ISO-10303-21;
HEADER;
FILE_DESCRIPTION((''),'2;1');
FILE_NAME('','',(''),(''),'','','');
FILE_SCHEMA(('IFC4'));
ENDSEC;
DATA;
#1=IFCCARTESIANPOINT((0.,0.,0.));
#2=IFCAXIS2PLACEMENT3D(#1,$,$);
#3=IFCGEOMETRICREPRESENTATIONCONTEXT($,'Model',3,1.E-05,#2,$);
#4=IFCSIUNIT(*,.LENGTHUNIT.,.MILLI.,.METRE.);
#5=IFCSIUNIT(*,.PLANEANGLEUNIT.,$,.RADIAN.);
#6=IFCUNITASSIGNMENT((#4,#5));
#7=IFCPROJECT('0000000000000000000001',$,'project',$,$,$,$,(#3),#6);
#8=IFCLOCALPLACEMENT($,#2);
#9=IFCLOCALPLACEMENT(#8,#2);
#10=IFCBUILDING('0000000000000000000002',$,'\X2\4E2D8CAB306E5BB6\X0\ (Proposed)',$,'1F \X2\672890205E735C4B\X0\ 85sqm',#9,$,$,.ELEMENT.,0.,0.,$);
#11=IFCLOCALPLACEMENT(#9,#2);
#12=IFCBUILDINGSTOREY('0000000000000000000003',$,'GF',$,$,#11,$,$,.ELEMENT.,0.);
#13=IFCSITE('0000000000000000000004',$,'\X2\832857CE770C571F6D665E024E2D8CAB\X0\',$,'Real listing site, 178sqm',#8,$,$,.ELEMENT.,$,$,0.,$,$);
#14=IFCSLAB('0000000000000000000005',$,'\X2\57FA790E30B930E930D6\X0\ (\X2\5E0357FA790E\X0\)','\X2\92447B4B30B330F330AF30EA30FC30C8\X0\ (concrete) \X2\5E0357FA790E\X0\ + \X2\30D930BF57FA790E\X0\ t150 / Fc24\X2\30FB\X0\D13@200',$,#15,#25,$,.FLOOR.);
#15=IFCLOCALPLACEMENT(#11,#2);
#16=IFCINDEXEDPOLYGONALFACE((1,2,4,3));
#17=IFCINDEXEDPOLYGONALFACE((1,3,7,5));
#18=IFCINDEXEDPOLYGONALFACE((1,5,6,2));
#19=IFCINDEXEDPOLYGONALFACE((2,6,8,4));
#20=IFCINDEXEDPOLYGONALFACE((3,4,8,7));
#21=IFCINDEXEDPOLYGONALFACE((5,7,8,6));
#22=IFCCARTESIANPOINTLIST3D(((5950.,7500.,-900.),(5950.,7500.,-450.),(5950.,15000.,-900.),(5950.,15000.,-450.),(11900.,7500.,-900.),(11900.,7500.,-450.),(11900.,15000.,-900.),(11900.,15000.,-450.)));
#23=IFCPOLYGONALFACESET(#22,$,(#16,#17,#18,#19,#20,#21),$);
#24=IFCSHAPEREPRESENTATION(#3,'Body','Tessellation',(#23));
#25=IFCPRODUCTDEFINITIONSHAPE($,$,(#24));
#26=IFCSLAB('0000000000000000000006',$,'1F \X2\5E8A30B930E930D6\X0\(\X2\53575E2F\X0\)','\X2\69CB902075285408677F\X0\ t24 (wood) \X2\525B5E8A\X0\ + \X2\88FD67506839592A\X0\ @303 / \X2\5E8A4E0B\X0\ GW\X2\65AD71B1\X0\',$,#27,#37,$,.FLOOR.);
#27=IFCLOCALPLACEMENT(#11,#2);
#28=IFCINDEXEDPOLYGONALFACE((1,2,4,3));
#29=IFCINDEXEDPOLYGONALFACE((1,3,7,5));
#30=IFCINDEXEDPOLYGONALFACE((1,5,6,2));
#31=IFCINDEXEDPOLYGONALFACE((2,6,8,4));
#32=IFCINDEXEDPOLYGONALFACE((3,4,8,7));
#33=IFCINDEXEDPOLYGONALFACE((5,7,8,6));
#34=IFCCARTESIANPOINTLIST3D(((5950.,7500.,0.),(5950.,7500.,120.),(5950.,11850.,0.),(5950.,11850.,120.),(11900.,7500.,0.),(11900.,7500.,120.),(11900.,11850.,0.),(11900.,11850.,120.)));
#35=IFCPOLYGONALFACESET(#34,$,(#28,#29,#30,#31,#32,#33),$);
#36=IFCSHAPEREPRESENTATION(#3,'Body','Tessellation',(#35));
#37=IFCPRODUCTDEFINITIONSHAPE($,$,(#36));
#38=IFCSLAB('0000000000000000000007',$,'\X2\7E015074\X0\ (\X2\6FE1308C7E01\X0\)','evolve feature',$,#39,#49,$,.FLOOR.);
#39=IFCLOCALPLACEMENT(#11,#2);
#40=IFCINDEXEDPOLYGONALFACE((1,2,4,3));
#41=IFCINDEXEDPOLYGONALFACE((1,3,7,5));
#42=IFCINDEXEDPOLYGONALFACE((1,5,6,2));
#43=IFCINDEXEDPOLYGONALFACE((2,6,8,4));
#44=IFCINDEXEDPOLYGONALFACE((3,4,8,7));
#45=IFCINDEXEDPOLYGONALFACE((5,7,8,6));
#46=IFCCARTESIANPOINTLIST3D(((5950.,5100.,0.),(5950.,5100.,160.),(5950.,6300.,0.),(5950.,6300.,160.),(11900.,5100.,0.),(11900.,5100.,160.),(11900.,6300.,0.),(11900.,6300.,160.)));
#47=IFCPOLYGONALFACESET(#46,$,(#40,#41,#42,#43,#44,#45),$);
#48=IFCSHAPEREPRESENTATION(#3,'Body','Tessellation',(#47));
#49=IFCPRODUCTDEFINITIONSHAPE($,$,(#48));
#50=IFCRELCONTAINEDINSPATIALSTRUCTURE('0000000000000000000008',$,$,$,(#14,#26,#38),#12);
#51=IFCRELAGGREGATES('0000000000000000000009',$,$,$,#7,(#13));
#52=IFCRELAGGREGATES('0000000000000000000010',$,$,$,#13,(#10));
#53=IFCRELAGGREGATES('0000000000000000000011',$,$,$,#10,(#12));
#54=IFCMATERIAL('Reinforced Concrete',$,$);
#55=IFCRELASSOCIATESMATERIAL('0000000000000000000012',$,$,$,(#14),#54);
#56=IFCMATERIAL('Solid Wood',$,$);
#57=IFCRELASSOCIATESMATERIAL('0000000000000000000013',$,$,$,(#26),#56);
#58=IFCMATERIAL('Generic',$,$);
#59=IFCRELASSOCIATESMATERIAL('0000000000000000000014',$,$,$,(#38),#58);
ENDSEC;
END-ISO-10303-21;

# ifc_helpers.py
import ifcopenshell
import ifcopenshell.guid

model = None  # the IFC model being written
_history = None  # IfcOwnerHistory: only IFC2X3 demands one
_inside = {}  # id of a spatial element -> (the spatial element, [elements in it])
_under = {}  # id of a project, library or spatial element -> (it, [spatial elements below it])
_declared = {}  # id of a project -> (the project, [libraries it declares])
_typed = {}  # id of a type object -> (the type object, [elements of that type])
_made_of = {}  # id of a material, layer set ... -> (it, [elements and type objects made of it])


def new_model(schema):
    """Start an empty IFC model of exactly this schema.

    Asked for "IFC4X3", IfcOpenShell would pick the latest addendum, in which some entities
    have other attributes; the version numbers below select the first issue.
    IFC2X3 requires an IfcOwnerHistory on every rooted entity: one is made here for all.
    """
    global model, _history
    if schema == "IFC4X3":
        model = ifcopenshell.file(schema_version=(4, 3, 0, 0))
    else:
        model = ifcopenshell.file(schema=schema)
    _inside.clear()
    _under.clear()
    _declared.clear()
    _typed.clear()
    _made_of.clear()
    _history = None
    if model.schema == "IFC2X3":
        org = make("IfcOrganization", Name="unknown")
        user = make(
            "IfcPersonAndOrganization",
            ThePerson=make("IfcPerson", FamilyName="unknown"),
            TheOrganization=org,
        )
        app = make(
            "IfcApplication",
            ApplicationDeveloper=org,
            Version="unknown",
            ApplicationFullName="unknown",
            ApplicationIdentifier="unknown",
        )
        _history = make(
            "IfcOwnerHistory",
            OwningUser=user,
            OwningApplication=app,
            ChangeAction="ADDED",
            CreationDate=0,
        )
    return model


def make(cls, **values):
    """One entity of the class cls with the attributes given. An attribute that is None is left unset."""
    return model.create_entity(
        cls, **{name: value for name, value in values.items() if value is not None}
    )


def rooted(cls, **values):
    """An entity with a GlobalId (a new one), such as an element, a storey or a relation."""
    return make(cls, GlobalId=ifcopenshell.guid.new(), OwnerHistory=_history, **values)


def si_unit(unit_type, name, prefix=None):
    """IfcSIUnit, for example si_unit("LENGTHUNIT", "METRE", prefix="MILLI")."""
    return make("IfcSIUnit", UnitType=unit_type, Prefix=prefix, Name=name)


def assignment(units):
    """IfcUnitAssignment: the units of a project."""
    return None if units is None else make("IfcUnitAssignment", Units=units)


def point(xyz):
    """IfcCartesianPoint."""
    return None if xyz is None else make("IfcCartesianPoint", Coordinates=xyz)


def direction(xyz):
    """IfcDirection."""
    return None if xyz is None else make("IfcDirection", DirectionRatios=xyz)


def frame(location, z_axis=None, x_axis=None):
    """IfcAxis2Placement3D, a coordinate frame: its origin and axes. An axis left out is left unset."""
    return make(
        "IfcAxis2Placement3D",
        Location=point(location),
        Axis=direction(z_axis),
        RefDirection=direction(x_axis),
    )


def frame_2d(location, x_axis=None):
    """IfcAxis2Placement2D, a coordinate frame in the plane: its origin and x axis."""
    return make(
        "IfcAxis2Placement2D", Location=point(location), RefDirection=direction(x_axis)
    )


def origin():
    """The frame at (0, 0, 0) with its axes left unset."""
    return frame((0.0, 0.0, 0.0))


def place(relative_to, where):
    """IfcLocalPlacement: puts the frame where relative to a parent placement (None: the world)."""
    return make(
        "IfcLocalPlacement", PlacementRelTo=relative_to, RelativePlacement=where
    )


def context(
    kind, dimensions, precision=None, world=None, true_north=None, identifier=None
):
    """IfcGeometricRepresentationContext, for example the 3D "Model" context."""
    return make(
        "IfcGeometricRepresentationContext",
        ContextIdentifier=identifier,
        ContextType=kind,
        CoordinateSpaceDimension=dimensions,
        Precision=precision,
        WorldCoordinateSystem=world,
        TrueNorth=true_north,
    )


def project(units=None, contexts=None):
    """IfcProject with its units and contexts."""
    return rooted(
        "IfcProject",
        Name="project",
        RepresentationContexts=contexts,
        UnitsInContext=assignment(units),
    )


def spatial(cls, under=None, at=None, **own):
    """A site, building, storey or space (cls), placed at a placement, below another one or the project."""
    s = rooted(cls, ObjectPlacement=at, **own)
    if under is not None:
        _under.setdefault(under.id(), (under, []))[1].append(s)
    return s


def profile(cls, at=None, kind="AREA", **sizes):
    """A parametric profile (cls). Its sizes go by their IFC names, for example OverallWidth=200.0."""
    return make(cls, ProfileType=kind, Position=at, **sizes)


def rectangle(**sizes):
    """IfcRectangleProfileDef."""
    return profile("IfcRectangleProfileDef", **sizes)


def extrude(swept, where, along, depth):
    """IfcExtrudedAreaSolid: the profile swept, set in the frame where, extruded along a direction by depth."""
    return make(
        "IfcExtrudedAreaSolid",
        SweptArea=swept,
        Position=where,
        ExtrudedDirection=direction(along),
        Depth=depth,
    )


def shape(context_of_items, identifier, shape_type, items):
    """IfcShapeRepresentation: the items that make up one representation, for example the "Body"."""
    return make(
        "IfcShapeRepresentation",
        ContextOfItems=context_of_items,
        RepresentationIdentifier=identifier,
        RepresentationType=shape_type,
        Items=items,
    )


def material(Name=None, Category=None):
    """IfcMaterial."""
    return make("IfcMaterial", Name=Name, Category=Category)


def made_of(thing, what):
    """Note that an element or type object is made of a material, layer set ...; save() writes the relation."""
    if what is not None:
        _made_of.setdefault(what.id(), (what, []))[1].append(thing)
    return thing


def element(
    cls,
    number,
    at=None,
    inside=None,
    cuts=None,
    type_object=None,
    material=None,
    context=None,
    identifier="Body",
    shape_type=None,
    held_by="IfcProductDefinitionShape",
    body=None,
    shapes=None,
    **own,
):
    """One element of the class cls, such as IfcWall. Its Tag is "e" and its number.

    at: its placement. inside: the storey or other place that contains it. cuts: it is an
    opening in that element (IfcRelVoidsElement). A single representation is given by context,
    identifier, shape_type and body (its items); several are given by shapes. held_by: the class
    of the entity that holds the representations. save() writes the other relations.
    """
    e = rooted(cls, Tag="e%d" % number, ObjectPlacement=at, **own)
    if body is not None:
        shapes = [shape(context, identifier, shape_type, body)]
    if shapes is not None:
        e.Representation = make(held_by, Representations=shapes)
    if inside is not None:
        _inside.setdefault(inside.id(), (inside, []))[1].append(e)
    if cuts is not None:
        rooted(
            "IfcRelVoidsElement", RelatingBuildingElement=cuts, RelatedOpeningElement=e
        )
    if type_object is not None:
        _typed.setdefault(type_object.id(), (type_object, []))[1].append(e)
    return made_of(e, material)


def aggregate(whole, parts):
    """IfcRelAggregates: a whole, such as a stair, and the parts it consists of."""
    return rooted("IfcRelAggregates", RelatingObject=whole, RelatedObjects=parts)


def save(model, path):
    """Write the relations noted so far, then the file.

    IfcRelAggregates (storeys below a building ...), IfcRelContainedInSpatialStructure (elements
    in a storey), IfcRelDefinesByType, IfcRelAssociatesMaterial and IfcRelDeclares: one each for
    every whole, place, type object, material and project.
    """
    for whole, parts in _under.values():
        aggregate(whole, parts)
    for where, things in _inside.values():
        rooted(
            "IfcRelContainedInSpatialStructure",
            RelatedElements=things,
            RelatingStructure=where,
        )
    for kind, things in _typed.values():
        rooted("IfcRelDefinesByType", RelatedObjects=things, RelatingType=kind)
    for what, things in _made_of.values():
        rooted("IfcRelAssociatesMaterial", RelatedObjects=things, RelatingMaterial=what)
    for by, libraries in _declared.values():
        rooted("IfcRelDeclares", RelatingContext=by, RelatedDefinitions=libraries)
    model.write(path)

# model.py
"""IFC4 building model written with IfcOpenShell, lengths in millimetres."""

from ifc_helpers import new_model, si_unit, frame, frame_2d, origin, place, context, project, spatial, rectangle, extrude, material, element, save


model = new_model("IFC4")

# Units and contexts
model_context = context("Model", 3, precision=1e-05, world=origin())
ifc_project = project(units=[si_unit("LENGTHUNIT", "METRE", prefix="MILLI"), si_unit("PLANEANGLEUNIT", "RADIAN")], contexts=[model_context])

# Site, building, storey
site_placement = place(None, origin())
site = spatial("IfcSite", under=ifc_project, at=site_placement, Name="茨城県土浦市中貫", ObjectType="Real listing site, 178sqm", CompositionType="ELEMENT", RefElevation=0.0)
building_placement = place(site_placement, origin())
building = spatial("IfcBuilding", under=site, at=building_placement, Name="中貫の家 (Proposed)", ObjectType="1F 木造平屋 85sqm", CompositionType="ELEMENT", ElevationOfRefHeight=0.0, ElevationOfTerrain=0.0)
storey_placement = place(building_placement, origin())
storey = spatial("IfcBuildingStorey", under=building, at=storey_placement, Name="GF", CompositionType="ELEMENT", Elevation=0.0)

# Slabs
ifc_material_1 = material(Name="Reinforced Concrete")
slab_1_placement = place(storey_placement, frame((2975.0, 3750.0, -450.0)))
element("IfcSlab", 1, at=slab_1_placement, inside=storey, material=ifc_material_1, Name="基礎スラブ (布基礎)", Description="鉄筋コンクリート (concrete) 布基礎 + ベタ基礎 t150 / Fc24・D13@200", PredefinedType="FLOOR", context=model_context, shape_type="SweptSolid", body=[
    extrude(rectangle(XDim=5950.0, YDim=7500.0, at=frame_2d((2975.0, 3750.0))), frame((2975.0, 3750.0, -450.0)), (0.0, 0.0, 1.0), 450.0),
])
ifc_material_2 = material(Name="Solid Wood")
slab_2_placement = place(storey_placement, frame((2975.0, 3750.0, 0.0)))
element("IfcSlab", 2, at=slab_2_placement, inside=storey, material=ifc_material_2, Name="1F 床スラブ(南帯)", Description="構造用合板 t24 (wood) 剛床 + 製材根太 @303 / 床下 GW断熱", PredefinedType="FLOOR", context=model_context, shape_type="SweptSolid", body=[
    extrude(rectangle(XDim=5950.0, YDim=4350.0, at=frame_2d((2975.0, 2175.0))), frame((2975.0, 3750.0, 0.0)), (0.0, 0.0, 1.0), 120.0),
])
ifc_material_3 = material(Name="Generic")
slab_3_placement = place(storey_placement, frame((2975.0, 2550.0, 0.0)))
element("IfcSlab", 3, at=slab_3_placement, inside=storey, material=ifc_material_3, Name="縁側 (濡れ縁)", Description="evolve feature", PredefinedType="FLOOR", context=model_context, shape_type="SweptSolid", body=[
    extrude(rectangle(XDim=5950.0, YDim=1200.0, at=frame_2d((2975.0, 600.0))), frame((2975.0, 2550.0, 0.0)), (0.0, 0.0, 1.0), 160.0),
])

save(model, "model.ifc")
